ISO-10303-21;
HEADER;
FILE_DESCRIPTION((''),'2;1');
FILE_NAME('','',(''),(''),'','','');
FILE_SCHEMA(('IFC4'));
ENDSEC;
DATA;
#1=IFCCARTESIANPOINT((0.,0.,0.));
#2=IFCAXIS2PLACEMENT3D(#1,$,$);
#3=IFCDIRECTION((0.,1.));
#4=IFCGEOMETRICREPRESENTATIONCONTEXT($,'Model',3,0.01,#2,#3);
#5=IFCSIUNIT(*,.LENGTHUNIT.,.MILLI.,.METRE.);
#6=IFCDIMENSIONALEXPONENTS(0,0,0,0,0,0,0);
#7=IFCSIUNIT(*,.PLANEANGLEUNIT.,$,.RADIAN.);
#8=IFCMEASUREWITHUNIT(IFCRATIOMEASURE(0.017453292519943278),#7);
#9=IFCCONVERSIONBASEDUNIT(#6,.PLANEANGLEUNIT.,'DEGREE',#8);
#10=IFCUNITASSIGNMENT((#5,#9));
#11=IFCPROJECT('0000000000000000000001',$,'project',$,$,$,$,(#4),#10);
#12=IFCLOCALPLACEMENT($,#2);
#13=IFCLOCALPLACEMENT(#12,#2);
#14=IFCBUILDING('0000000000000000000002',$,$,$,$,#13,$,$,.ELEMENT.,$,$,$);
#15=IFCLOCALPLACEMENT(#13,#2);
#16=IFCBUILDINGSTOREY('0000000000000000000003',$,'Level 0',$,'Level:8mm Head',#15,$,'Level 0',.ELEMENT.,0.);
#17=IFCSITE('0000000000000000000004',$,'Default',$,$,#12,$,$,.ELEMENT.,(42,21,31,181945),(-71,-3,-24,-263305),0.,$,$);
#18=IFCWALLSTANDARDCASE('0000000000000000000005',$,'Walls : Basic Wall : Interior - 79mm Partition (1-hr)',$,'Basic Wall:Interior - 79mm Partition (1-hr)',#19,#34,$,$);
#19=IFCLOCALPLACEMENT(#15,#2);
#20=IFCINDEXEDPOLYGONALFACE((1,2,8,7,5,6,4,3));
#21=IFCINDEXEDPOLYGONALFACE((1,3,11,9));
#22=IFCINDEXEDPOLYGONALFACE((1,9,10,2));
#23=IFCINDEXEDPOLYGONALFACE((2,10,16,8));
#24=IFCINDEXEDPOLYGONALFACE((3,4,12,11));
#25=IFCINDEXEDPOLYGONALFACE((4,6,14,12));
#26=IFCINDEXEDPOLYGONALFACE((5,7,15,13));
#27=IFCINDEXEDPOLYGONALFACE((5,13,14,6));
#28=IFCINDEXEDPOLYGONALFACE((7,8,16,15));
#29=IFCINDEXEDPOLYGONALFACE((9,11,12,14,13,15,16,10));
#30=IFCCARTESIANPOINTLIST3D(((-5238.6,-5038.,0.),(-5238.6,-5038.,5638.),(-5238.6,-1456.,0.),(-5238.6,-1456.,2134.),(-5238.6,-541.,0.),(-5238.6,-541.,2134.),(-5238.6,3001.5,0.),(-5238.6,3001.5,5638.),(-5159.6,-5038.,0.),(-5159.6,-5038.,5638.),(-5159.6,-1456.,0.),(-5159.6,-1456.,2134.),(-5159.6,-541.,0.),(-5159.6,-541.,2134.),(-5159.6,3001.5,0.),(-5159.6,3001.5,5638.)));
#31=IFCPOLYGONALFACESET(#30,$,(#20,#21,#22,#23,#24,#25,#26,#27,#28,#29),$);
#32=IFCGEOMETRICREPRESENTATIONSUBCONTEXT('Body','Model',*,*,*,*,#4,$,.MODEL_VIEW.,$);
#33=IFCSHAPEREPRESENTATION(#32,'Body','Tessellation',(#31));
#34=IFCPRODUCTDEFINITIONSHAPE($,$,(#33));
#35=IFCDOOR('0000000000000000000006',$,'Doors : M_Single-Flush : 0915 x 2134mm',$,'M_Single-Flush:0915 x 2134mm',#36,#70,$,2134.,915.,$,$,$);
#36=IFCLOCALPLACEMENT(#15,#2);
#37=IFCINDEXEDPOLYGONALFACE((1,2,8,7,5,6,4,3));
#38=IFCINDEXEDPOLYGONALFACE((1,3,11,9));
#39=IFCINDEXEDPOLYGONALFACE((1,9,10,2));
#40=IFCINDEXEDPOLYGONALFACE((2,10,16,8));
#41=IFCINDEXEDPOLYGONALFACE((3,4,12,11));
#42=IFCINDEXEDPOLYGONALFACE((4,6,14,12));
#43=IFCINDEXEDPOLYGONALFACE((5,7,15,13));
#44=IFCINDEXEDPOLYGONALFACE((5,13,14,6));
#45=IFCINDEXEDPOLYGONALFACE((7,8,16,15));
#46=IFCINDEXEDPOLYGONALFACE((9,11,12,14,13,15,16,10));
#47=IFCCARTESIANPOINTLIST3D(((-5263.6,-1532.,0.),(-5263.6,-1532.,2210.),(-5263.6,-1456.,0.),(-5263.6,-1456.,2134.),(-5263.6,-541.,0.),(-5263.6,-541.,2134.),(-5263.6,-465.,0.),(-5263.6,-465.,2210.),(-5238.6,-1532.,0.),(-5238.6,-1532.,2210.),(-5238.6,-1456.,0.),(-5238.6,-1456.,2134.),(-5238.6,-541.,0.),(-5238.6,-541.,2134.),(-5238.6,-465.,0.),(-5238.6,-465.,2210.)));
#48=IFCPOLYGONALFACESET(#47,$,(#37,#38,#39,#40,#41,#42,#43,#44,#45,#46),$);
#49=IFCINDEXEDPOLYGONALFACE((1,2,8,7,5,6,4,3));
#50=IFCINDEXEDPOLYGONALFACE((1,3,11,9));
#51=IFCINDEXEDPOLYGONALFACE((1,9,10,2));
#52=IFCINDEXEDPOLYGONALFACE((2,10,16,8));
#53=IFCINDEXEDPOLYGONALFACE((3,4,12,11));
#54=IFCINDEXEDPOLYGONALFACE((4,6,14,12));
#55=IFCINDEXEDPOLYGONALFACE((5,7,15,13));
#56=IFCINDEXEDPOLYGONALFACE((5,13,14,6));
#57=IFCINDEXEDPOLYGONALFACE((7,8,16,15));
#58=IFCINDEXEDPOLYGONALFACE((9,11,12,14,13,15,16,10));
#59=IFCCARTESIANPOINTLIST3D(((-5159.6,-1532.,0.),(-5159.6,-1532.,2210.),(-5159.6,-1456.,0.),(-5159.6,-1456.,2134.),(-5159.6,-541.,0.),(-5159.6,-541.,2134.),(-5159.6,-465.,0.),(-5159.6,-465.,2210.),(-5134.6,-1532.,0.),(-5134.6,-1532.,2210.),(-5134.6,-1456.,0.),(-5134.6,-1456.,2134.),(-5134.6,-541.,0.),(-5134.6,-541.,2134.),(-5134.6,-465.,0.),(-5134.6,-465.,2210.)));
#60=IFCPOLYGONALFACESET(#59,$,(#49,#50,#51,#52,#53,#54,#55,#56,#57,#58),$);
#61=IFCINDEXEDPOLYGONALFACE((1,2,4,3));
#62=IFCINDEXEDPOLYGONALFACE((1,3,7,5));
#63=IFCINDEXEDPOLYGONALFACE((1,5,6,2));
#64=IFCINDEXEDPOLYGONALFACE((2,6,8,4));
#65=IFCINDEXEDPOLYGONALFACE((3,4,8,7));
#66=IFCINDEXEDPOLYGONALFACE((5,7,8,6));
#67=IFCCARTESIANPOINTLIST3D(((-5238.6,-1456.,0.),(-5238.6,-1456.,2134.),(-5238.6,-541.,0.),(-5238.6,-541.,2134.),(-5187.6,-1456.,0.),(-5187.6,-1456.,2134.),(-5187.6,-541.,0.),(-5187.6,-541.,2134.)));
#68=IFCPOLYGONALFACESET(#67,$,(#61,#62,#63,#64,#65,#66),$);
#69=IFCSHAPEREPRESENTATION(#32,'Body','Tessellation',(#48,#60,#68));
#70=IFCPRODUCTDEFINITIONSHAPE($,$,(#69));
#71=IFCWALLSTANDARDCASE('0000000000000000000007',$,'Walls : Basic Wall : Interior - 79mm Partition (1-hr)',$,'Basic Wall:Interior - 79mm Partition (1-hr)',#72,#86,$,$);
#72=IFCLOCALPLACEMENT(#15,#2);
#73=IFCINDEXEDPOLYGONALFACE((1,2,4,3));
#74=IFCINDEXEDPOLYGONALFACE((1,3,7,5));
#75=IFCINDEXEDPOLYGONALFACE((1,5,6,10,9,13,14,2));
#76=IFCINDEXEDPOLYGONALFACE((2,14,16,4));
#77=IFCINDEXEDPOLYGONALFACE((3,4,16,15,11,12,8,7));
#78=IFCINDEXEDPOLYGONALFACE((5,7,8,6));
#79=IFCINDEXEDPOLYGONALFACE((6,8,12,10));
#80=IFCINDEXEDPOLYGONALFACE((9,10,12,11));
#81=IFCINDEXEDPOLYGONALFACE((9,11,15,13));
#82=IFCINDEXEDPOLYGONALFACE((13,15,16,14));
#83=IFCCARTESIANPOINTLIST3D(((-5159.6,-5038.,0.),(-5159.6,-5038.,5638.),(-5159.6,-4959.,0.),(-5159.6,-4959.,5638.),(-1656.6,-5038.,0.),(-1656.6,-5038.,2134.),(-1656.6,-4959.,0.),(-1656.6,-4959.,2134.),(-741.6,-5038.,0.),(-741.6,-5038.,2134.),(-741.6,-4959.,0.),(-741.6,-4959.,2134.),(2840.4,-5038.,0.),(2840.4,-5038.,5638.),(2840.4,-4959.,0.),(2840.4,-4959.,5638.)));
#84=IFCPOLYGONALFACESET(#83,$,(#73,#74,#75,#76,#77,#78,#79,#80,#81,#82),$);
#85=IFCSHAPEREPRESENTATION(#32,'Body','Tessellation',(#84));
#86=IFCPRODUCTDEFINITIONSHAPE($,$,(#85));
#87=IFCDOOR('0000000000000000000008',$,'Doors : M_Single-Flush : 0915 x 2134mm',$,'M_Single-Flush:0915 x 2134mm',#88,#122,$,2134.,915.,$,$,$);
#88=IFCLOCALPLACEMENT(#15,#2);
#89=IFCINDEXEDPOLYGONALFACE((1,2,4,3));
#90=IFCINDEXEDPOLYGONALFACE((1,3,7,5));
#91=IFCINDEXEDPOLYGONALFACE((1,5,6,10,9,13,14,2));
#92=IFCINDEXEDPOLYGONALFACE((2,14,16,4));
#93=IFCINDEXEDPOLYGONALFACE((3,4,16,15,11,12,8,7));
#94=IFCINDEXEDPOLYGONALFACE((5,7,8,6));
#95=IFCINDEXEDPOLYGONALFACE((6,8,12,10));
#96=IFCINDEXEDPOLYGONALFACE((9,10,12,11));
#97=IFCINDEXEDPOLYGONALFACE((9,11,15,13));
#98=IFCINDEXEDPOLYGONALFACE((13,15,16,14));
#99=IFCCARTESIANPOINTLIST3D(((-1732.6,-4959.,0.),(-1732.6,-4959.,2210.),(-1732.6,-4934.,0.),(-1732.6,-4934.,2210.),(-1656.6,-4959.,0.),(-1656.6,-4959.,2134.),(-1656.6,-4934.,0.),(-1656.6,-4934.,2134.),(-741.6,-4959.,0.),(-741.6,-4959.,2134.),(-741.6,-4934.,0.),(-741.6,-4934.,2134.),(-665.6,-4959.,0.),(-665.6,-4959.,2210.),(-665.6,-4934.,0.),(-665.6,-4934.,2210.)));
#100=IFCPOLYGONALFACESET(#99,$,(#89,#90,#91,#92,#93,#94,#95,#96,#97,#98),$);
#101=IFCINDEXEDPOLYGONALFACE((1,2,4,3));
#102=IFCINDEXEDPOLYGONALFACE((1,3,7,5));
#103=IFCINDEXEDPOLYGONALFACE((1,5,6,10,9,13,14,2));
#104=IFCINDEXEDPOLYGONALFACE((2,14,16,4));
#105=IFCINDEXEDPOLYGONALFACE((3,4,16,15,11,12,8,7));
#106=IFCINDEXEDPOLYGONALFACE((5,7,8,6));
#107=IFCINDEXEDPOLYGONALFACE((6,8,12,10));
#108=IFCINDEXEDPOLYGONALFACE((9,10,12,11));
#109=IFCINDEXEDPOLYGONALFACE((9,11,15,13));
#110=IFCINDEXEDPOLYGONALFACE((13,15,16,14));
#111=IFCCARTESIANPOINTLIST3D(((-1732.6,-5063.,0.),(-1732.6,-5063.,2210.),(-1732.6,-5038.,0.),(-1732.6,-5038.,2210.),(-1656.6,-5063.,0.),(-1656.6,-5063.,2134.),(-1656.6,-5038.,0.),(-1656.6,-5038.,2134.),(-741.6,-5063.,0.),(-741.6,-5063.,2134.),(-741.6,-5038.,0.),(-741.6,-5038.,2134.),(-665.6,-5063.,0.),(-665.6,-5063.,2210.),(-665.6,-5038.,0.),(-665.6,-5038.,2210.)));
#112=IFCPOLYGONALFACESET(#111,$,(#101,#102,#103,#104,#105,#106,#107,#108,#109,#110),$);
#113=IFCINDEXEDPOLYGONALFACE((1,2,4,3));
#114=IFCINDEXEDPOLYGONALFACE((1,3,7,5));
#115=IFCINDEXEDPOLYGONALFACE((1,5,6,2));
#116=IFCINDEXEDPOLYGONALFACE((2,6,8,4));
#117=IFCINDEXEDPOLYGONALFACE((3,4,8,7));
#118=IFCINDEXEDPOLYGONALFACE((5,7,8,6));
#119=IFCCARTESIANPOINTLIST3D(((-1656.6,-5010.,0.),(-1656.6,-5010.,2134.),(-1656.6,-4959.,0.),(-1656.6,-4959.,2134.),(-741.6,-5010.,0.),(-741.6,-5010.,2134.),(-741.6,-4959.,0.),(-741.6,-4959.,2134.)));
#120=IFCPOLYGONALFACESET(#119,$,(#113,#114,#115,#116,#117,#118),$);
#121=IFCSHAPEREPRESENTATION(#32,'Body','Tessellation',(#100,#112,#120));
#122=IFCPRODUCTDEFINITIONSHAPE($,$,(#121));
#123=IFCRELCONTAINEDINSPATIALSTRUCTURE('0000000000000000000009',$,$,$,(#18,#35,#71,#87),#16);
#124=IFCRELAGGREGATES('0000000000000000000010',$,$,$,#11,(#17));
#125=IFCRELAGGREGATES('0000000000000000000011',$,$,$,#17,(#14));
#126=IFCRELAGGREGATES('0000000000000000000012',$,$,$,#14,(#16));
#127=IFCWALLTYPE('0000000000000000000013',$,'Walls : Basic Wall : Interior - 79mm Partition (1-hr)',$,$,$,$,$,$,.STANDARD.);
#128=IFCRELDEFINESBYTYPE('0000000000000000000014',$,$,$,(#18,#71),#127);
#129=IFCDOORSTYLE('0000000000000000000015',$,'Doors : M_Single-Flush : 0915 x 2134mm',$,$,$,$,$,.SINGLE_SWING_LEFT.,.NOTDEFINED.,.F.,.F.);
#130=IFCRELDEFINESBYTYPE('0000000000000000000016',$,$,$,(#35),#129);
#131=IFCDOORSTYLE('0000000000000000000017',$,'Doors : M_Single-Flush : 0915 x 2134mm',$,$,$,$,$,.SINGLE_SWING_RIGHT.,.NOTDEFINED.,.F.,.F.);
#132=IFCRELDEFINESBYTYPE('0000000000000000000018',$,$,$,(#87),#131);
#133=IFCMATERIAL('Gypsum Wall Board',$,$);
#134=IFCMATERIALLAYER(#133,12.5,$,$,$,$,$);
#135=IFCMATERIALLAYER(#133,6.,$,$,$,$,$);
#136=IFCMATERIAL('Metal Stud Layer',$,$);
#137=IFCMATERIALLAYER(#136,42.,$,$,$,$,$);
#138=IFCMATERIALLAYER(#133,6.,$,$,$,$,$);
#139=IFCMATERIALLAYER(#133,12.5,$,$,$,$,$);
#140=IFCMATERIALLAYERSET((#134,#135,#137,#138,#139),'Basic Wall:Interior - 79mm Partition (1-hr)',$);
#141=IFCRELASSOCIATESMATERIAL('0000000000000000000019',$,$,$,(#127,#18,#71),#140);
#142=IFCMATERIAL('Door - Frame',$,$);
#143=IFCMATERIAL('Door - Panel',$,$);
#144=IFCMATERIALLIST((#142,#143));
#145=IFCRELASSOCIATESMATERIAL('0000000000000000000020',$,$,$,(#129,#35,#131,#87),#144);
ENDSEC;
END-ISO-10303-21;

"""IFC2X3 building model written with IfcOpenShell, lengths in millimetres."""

from ifc_helpers import new_model, entity, si_unit, converted_unit, direction, frame, frame_2d, origin, origin_2d_with_axis, place, context, subcontext, project, spatial, polyline, rectangle, outline, extrude, clip, bounded_halfspace, source, transform, mapped, material, material_list, layer, layer_set, layer_usage, type_object, type_shapes, element, fill, save


model = new_model("IFC2X3")

# Units and contexts
model_context = context("Model", 3, precision=0.01, world=origin(), true_north=direction((0.0, 1.0)))
body_context = subcontext(model_context, "Body", "Model", "MODEL_VIEW")
ifc_project = project(units=[si_unit("LENGTHUNIT", "METRE", prefix="MILLI"), converted_unit("PLANEANGLEUNIT", "DEGREE", entity("IfcRatioMeasure", 0.017453292519943278), si_unit("PLANEANGLEUNIT", "RADIAN"), dimensions=[0, 0, 0, 0, 0, 0, 0])], contexts=[model_context])

# Site, building, storey
site_placement = place(None, origin())
site = spatial("IfcSite", under=ifc_project, at=site_placement, Name="Default", CompositionType="ELEMENT", RefLatitude=(42, 21, 31, 181945), RefLongitude=(-71, -3, -24, -263305), RefElevation=0.0)
building_placement = place(site_placement, origin())
building = spatial("IfcBuilding", under=site, at=building_placement, CompositionType="ELEMENT")
storey_placement = place(building_placement, origin())
storey = spatial("IfcBuildingStorey", under=building, at=storey_placement, Name="Level 0", ObjectType="Level:8mm Head", LongName="Level 0", CompositionType="ELEMENT", Elevation=0.0)

# Shared definitions
ifc_material_1 = material(Name="Metal Stud Layer")
ifc_material_2 = material(Name="Gypsum Wall Board")

# Shared definitions
ifc_material_3 = material(Name="Door - Frame")
ifc_material_4 = material(Name="Door - Panel")
ifc_material_list = material_list([ifc_material_3, ifc_material_4])

# Walls, openings, doors
ifc_layer_1 = layer(ifc_material_2, 12.5)
ifc_layer_2 = layer(ifc_material_2, 6.0)
ifc_layer_3 = layer(ifc_material_1, 42.0)
ifc_layer_4 = layer(ifc_material_2, 6.0)
ifc_layer_5 = layer(ifc_material_2, 12.5)
ifc_layer_set_1 = layer_set([ifc_layer_1, ifc_layer_2, ifc_layer_3, ifc_layer_4, ifc_layer_5], Name="Basic Wall:Interior - 79mm Partition (1-hr)")
ifc_layer_usage_1 = layer_usage(ifc_layer_set_1, "AXIS2", "NEGATIVE", 39.5)
wall_type_1 = type_object("IfcWallType", Name="Walls : Basic Wall : Interior - 79mm Partition (1-hr)", PredefinedType="STANDARD", material=ifc_layer_set_1)
wall_1_placement = place(storey_placement, frame((-5199.1, 3001.5, 0.0), z_axis=(0.0, 0.0, 1.0), x_axis=(0.0, -1.0, 0.0)))
wall_1 = element("IfcWallStandardCase", 1, at=wall_1_placement, inside=storey, type_object=wall_type_1, material=ifc_layer_usage_1, Name="Walls : Basic Wall : Interior - 79mm Partition (1-hr)", ObjectType="Basic Wall:Interior - 79mm Partition (1-hr)", context=body_context, shape_type="Clipping", body=[
    clip(extrude(rectangle(XDim=8039.5, YDim=79.0, at=frame_2d((4019.8, 0.0), x_axis=(1.0, 0.0))), origin(), (0.0, 0.0, 1.0), 5638.0), bounded_halfspace(frame((0.0, -39.5, 5638.0), z_axis=(0.0, 0.0, -1.0), x_axis=(1.0, 0.0, 0.0)), True, frame((0.0, -39.5, 5638.0)), polyline([(0.0, 0.0), (2450439.6, 0.0), (2450439.6, 24079.2), (2426360.4, 24079.2), (0.0, 24079.2), (0.0, 0.0)]))),
])
opening_1_placement = place(wall_1_placement, frame((4457.5, 39.5, 0.0)))
opening_1 = element("IfcOpeningElement", 2, at=opening_1_placement, cuts=wall_1, ObjectType="Opening", context=body_context, shape_type="SweptSolid", body=[
    extrude(rectangle(XDim=915.0, YDim=2134.0, at=frame_2d((1067.0, 457.5), x_axis=(0.0, -1.0))), frame((0.0, 0.0, 0.0), z_axis=(0.0, -1.0, 0.0), x_axis=(0.0, 0.0, 1.0)), (0.0, 0.0, 1.0), 79.0),
])
door_style_1 = type_object("IfcDoorStyle", Name="Doors : M_Single-Flush : 0915 x 2134mm", ConstructionType="NOTDEFINED", OperationType="SINGLE_SWING_LEFT", ParameterTakesPrecedence=False, Sizeable=False, material=ifc_material_list)
shared_shape_1 = source(origin(), body_context, "Body", "SweptSolid", [
    extrude(outline(polyline([(-533.5, -1124.0), (533.5, -1124.0), (533.5, 1086.0), (457.5, 1086.0), (457.5, -1048.0), (-457.5, -1048.0), (-457.5, 1086.0), (-533.5, 1086.0), (-533.5, -1124.0)])), frame((457.5, 104.0, 1086.0), z_axis=(0.0, -1.0, 0.0), x_axis=(-1.0, 0.0, 0.0)), (0.0, 0.0, 1.0), 25.0),
    extrude(outline(polyline([(-1124.0, -533.5), (1086.0, -533.5), (1086.0, -457.5), (-1048.0, -457.5), (-1048.0, 457.5), (1086.0, 457.5), (1086.0, 533.5), (-1124.0, 533.5), (-1124.0, -533.5)])), frame((457.5, 0.0, 1086.0), z_axis=(0.0, -1.0, 0.0), x_axis=(0.0, 0.0, -1.0)), (0.0, 0.0, 1.0), 25.0),
    extrude(rectangle(XDim=915.0, YDim=51.0, at=origin_2d_with_axis()), frame((457.5, 53.5, 0.0)), (0.0, 0.0, 1.0), 2134.0),
])
type_shapes(door_style_1, [shared_shape_1])
door_1_placement = place(opening_1_placement, frame((0.0, 0.0, 0.0), z_axis=(0.0, 0.0, 1.0), x_axis=(-1.0, 0.0, 0.0)))
door_1 = element("IfcDoor", 3, at=door_1_placement, inside=storey, type_object=door_style_1, material=ifc_material_list, Name="Doors : M_Single-Flush : 0915 x 2134mm", ObjectType="M_Single-Flush:0915 x 2134mm", OverallHeight=2134.0, OverallWidth=915.0, context=body_context, shape_type="MappedRepresentation", body=[
    mapped(shared_shape_1, transform((0.0, 0.0, 0.0), scale=1.0)),
])
fill(opening_1, door_1)
wall_2_placement = place(storey_placement, frame((-5159.6, -4998.5, 0.0)))
wall_2 = element("IfcWallStandardCase", 4, at=wall_2_placement, inside=storey, type_object=wall_type_1, material=ifc_layer_usage_1, Name="Walls : Basic Wall : Interior - 79mm Partition (1-hr)", ObjectType="Basic Wall:Interior - 79mm Partition (1-hr)", context=body_context, shape_type="Clipping", body=[
    clip(extrude(rectangle(XDim=8000.0, YDim=79.0, at=frame_2d((4000.0, 0.0), x_axis=(1.0, 0.0))), origin(), (0.0, 0.0, 1.0), 5638.0), bounded_halfspace(frame((0.0, -39.5, 5638.0), z_axis=(0.0, 0.0, -1.0), x_axis=(0.0, -1.0, 0.0)), True, frame((0.0, -39.5, 5638.0)), polyline([(0.0, 0.0), (2414320.8, 0.0), (2438400.0, 0.0), (2438400.0, 24079.2), (0.0, 24079.2), (0.0, 0.0)]))),
])
opening_2_placement = place(wall_2_placement, frame((3503.0, -39.5, 0.0)))
opening_2 = element("IfcOpeningElement", 5, at=opening_2_placement, cuts=wall_2, ObjectType="Opening", context=body_context, shape_type="SweptSolid", body=[
    extrude(rectangle(XDim=915.0, YDim=2134.0, at=frame_2d((1067.0, 457.5), x_axis=(0.0, 1.0))), frame((0.0, 0.0, 0.0), z_axis=(0.0, 1.0, 0.0), x_axis=(0.0, 0.0, 1.0)), (0.0, 0.0, 1.0), 79.0),
])
door_style_2 = type_object("IfcDoorStyle", Name="Doors : M_Single-Flush : 0915 x 2134mm", ConstructionType="NOTDEFINED", OperationType="SINGLE_SWING_RIGHT", ParameterTakesPrecedence=False, Sizeable=False, material=ifc_material_list)
shared_shape_2 = source(origin(), body_context, "Body", "SweptSolid", [
    extrude(outline(polyline([(-533.5, -1124.0), (533.5, -1124.0), (533.5, 1086.0), (457.5, 1086.0), (457.5, -1048.0), (-457.5, -1048.0), (-457.5, 1086.0), (-533.5, 1086.0), (-533.5, -1124.0)])), frame((457.5, 79.0, 1086.0), z_axis=(0.0, 1.0, 0.0), x_axis=(1.0, 0.0, 0.0)), (0.0, 0.0, 1.0), 25.0),
    extrude(outline(polyline([(-1124.0, -533.5), (1086.0, -533.5), (1086.0, -457.5), (-1048.0, -457.5), (-1048.0, 457.5), (1086.0, 457.5), (1086.0, 533.5), (-1124.0, 533.5), (-1124.0, -533.5)])), frame((457.5, -25.0, 1086.0), z_axis=(0.0, 1.0, 0.0), x_axis=(0.0, 0.0, -1.0)), (0.0, 0.0, 1.0), 25.0),
    extrude(rectangle(XDim=51.0, YDim=915.0, at=origin_2d_with_axis()), frame((457.5, 53.5, 0.0), z_axis=(0.0, 0.0, 1.0), x_axis=(0.0, 1.0, 0.0)), (0.0, 0.0, 1.0), 2134.0),
])
type_shapes(door_style_2, [shared_shape_2])
door_2_placement = place(opening_2_placement, origin())
door_2 = element("IfcDoor", 6, at=door_2_placement, inside=storey, type_object=door_style_2, material=ifc_material_list, Name="Doors : M_Single-Flush : 0915 x 2134mm", ObjectType="M_Single-Flush:0915 x 2134mm", OverallHeight=2134.0, OverallWidth=915.0, context=body_context, shape_type="MappedRepresentation", body=[
    mapped(shared_shape_2, transform((0.0, 0.0, 0.0), scale=1.0)),
])
fill(opening_2, door_2)

save(model, "model.ifc")
